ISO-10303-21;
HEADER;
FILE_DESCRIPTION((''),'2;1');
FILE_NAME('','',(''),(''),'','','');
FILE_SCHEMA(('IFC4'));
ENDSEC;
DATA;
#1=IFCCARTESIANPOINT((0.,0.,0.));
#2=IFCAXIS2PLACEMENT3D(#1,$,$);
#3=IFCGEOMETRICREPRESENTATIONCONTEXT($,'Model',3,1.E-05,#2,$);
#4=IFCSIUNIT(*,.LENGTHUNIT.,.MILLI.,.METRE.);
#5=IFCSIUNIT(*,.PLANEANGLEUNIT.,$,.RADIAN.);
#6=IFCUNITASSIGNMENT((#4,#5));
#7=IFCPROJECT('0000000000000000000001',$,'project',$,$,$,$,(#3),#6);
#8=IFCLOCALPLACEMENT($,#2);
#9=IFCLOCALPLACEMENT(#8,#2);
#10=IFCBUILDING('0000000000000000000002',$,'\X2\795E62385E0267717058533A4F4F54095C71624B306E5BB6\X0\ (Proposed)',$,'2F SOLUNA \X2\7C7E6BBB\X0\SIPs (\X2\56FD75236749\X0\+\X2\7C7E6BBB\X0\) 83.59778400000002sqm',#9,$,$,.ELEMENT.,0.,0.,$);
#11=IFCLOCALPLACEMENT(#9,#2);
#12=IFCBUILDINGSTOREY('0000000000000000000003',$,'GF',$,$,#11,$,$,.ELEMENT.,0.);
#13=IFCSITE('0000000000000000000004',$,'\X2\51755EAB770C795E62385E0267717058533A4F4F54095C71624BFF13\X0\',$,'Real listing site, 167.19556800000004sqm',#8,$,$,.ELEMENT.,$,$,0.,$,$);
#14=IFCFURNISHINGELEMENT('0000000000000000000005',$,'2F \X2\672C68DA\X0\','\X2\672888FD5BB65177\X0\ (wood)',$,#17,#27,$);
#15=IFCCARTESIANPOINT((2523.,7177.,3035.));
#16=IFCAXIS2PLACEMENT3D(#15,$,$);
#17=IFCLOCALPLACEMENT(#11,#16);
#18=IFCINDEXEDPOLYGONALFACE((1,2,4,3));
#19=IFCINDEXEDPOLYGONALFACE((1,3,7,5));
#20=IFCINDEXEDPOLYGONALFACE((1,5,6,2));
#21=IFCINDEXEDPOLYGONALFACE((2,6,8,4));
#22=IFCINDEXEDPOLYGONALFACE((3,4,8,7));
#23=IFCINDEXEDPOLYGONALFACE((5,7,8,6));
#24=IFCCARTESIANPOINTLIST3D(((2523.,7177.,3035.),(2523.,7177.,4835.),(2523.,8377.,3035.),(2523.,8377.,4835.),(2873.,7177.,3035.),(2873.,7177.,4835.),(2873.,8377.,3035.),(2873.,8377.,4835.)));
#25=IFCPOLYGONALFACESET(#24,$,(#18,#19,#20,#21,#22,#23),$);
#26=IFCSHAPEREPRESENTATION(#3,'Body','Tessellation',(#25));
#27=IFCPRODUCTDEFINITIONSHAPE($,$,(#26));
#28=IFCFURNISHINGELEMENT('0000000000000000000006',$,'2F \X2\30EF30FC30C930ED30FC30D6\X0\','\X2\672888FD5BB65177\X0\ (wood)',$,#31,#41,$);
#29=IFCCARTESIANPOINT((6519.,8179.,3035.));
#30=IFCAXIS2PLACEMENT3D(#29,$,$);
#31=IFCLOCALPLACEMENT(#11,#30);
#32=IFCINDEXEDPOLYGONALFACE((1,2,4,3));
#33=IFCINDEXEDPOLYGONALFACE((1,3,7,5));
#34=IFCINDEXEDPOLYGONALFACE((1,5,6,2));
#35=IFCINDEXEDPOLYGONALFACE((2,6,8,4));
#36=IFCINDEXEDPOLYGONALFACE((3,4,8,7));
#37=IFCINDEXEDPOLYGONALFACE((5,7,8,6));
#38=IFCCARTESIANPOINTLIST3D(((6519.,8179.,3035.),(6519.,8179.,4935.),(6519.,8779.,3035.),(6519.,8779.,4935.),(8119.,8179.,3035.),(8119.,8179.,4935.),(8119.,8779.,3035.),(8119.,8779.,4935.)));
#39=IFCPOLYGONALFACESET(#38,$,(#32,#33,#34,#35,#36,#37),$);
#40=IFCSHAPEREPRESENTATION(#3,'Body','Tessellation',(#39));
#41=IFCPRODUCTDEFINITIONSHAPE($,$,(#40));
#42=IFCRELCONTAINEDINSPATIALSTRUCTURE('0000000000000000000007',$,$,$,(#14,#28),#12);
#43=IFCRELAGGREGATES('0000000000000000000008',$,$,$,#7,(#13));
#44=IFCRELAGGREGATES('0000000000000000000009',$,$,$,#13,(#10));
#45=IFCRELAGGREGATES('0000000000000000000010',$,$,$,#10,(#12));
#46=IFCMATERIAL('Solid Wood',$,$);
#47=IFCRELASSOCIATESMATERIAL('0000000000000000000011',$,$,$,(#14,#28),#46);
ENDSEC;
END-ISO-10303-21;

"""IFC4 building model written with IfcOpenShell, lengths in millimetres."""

from ifc_helpers import new_model, si_unit, frame, frame_2d, origin, place, context, project, spatial, rectangle, extrude, material, element, save


model = new_model("IFC4")

# Units and contexts
model_context = context("Model", 3, precision=1e-05, world=origin())
ifc_project = project(units=[si_unit("LENGTHUNIT", "METRE", prefix="MILLI"), si_unit("PLANEANGLEUNIT", "RADIAN")], contexts=[model_context])

# Site, building, storey
site_placement = place(None, origin())
site = spatial("IfcSite", under=ifc_project, at=site_placement, Name="兵庫県神戸市東灘区住吉山手３", ObjectType="Real listing site, 167.19556800000004sqm", CompositionType="ELEMENT", RefElevation=0.0)
building_placement = place(site_placement, origin())
building = spatial("IfcBuilding", under=site, at=building_placement, Name="神戸市東灘区住吉山手の家 (Proposed)", ObjectType="2F SOLUNA 籾殻SIPs (国産杉+籾殻) 83.59778400000002sqm", CompositionType="ELEMENT", ElevationOfRefHeight=0.0, ElevationOfTerrain=0.0)
storey_placement = place(building_placement, origin())
storey = spatial("IfcBuildingStorey", under=building, at=storey_placement, Name="GF", CompositionType="ELEMENT", Elevation=0.0)

# Shared definitions
ifc_material_1 = material(Name="Solid Wood")

# Furnishing elements
furnishing_1_placement = place(storey_placement, frame((2523.0, 7177.0, 3035.0)))
element("IfcFurnishingElement", 1, at=furnishing_1_placement, inside=storey, material=ifc_material_1, Name="2F 本棚", Description="木製家具 (wood)", context=model_context, shape_type="SweptSolid", body=[
    extrude(rectangle(XDim=350.0, YDim=1200.0, at=frame_2d((175.0, 600.0))), frame((2523.0, 7177.0, 3035.0)), (0.0, 0.0, 1.0), 1800.0),
])
furnishing_2_placement = place(storey_placement, frame((6519.0, 8179.0, 3035.0)))
element("IfcFurnishingElement", 2, at=furnishing_2_placement, inside=storey, material=ifc_material_1, Name="2F ワードローブ", Description="木製家具 (wood)", context=model_context, shape_type="SweptSolid", body=[
    extrude(rectangle(XDim=1600.0, YDim=600.0, at=frame_2d((800.0, 300.0))), frame((6519.0, 8179.0, 3035.0)), (0.0, 0.0, 1.0), 1900.0),
])

save(model, "model.ifc")
